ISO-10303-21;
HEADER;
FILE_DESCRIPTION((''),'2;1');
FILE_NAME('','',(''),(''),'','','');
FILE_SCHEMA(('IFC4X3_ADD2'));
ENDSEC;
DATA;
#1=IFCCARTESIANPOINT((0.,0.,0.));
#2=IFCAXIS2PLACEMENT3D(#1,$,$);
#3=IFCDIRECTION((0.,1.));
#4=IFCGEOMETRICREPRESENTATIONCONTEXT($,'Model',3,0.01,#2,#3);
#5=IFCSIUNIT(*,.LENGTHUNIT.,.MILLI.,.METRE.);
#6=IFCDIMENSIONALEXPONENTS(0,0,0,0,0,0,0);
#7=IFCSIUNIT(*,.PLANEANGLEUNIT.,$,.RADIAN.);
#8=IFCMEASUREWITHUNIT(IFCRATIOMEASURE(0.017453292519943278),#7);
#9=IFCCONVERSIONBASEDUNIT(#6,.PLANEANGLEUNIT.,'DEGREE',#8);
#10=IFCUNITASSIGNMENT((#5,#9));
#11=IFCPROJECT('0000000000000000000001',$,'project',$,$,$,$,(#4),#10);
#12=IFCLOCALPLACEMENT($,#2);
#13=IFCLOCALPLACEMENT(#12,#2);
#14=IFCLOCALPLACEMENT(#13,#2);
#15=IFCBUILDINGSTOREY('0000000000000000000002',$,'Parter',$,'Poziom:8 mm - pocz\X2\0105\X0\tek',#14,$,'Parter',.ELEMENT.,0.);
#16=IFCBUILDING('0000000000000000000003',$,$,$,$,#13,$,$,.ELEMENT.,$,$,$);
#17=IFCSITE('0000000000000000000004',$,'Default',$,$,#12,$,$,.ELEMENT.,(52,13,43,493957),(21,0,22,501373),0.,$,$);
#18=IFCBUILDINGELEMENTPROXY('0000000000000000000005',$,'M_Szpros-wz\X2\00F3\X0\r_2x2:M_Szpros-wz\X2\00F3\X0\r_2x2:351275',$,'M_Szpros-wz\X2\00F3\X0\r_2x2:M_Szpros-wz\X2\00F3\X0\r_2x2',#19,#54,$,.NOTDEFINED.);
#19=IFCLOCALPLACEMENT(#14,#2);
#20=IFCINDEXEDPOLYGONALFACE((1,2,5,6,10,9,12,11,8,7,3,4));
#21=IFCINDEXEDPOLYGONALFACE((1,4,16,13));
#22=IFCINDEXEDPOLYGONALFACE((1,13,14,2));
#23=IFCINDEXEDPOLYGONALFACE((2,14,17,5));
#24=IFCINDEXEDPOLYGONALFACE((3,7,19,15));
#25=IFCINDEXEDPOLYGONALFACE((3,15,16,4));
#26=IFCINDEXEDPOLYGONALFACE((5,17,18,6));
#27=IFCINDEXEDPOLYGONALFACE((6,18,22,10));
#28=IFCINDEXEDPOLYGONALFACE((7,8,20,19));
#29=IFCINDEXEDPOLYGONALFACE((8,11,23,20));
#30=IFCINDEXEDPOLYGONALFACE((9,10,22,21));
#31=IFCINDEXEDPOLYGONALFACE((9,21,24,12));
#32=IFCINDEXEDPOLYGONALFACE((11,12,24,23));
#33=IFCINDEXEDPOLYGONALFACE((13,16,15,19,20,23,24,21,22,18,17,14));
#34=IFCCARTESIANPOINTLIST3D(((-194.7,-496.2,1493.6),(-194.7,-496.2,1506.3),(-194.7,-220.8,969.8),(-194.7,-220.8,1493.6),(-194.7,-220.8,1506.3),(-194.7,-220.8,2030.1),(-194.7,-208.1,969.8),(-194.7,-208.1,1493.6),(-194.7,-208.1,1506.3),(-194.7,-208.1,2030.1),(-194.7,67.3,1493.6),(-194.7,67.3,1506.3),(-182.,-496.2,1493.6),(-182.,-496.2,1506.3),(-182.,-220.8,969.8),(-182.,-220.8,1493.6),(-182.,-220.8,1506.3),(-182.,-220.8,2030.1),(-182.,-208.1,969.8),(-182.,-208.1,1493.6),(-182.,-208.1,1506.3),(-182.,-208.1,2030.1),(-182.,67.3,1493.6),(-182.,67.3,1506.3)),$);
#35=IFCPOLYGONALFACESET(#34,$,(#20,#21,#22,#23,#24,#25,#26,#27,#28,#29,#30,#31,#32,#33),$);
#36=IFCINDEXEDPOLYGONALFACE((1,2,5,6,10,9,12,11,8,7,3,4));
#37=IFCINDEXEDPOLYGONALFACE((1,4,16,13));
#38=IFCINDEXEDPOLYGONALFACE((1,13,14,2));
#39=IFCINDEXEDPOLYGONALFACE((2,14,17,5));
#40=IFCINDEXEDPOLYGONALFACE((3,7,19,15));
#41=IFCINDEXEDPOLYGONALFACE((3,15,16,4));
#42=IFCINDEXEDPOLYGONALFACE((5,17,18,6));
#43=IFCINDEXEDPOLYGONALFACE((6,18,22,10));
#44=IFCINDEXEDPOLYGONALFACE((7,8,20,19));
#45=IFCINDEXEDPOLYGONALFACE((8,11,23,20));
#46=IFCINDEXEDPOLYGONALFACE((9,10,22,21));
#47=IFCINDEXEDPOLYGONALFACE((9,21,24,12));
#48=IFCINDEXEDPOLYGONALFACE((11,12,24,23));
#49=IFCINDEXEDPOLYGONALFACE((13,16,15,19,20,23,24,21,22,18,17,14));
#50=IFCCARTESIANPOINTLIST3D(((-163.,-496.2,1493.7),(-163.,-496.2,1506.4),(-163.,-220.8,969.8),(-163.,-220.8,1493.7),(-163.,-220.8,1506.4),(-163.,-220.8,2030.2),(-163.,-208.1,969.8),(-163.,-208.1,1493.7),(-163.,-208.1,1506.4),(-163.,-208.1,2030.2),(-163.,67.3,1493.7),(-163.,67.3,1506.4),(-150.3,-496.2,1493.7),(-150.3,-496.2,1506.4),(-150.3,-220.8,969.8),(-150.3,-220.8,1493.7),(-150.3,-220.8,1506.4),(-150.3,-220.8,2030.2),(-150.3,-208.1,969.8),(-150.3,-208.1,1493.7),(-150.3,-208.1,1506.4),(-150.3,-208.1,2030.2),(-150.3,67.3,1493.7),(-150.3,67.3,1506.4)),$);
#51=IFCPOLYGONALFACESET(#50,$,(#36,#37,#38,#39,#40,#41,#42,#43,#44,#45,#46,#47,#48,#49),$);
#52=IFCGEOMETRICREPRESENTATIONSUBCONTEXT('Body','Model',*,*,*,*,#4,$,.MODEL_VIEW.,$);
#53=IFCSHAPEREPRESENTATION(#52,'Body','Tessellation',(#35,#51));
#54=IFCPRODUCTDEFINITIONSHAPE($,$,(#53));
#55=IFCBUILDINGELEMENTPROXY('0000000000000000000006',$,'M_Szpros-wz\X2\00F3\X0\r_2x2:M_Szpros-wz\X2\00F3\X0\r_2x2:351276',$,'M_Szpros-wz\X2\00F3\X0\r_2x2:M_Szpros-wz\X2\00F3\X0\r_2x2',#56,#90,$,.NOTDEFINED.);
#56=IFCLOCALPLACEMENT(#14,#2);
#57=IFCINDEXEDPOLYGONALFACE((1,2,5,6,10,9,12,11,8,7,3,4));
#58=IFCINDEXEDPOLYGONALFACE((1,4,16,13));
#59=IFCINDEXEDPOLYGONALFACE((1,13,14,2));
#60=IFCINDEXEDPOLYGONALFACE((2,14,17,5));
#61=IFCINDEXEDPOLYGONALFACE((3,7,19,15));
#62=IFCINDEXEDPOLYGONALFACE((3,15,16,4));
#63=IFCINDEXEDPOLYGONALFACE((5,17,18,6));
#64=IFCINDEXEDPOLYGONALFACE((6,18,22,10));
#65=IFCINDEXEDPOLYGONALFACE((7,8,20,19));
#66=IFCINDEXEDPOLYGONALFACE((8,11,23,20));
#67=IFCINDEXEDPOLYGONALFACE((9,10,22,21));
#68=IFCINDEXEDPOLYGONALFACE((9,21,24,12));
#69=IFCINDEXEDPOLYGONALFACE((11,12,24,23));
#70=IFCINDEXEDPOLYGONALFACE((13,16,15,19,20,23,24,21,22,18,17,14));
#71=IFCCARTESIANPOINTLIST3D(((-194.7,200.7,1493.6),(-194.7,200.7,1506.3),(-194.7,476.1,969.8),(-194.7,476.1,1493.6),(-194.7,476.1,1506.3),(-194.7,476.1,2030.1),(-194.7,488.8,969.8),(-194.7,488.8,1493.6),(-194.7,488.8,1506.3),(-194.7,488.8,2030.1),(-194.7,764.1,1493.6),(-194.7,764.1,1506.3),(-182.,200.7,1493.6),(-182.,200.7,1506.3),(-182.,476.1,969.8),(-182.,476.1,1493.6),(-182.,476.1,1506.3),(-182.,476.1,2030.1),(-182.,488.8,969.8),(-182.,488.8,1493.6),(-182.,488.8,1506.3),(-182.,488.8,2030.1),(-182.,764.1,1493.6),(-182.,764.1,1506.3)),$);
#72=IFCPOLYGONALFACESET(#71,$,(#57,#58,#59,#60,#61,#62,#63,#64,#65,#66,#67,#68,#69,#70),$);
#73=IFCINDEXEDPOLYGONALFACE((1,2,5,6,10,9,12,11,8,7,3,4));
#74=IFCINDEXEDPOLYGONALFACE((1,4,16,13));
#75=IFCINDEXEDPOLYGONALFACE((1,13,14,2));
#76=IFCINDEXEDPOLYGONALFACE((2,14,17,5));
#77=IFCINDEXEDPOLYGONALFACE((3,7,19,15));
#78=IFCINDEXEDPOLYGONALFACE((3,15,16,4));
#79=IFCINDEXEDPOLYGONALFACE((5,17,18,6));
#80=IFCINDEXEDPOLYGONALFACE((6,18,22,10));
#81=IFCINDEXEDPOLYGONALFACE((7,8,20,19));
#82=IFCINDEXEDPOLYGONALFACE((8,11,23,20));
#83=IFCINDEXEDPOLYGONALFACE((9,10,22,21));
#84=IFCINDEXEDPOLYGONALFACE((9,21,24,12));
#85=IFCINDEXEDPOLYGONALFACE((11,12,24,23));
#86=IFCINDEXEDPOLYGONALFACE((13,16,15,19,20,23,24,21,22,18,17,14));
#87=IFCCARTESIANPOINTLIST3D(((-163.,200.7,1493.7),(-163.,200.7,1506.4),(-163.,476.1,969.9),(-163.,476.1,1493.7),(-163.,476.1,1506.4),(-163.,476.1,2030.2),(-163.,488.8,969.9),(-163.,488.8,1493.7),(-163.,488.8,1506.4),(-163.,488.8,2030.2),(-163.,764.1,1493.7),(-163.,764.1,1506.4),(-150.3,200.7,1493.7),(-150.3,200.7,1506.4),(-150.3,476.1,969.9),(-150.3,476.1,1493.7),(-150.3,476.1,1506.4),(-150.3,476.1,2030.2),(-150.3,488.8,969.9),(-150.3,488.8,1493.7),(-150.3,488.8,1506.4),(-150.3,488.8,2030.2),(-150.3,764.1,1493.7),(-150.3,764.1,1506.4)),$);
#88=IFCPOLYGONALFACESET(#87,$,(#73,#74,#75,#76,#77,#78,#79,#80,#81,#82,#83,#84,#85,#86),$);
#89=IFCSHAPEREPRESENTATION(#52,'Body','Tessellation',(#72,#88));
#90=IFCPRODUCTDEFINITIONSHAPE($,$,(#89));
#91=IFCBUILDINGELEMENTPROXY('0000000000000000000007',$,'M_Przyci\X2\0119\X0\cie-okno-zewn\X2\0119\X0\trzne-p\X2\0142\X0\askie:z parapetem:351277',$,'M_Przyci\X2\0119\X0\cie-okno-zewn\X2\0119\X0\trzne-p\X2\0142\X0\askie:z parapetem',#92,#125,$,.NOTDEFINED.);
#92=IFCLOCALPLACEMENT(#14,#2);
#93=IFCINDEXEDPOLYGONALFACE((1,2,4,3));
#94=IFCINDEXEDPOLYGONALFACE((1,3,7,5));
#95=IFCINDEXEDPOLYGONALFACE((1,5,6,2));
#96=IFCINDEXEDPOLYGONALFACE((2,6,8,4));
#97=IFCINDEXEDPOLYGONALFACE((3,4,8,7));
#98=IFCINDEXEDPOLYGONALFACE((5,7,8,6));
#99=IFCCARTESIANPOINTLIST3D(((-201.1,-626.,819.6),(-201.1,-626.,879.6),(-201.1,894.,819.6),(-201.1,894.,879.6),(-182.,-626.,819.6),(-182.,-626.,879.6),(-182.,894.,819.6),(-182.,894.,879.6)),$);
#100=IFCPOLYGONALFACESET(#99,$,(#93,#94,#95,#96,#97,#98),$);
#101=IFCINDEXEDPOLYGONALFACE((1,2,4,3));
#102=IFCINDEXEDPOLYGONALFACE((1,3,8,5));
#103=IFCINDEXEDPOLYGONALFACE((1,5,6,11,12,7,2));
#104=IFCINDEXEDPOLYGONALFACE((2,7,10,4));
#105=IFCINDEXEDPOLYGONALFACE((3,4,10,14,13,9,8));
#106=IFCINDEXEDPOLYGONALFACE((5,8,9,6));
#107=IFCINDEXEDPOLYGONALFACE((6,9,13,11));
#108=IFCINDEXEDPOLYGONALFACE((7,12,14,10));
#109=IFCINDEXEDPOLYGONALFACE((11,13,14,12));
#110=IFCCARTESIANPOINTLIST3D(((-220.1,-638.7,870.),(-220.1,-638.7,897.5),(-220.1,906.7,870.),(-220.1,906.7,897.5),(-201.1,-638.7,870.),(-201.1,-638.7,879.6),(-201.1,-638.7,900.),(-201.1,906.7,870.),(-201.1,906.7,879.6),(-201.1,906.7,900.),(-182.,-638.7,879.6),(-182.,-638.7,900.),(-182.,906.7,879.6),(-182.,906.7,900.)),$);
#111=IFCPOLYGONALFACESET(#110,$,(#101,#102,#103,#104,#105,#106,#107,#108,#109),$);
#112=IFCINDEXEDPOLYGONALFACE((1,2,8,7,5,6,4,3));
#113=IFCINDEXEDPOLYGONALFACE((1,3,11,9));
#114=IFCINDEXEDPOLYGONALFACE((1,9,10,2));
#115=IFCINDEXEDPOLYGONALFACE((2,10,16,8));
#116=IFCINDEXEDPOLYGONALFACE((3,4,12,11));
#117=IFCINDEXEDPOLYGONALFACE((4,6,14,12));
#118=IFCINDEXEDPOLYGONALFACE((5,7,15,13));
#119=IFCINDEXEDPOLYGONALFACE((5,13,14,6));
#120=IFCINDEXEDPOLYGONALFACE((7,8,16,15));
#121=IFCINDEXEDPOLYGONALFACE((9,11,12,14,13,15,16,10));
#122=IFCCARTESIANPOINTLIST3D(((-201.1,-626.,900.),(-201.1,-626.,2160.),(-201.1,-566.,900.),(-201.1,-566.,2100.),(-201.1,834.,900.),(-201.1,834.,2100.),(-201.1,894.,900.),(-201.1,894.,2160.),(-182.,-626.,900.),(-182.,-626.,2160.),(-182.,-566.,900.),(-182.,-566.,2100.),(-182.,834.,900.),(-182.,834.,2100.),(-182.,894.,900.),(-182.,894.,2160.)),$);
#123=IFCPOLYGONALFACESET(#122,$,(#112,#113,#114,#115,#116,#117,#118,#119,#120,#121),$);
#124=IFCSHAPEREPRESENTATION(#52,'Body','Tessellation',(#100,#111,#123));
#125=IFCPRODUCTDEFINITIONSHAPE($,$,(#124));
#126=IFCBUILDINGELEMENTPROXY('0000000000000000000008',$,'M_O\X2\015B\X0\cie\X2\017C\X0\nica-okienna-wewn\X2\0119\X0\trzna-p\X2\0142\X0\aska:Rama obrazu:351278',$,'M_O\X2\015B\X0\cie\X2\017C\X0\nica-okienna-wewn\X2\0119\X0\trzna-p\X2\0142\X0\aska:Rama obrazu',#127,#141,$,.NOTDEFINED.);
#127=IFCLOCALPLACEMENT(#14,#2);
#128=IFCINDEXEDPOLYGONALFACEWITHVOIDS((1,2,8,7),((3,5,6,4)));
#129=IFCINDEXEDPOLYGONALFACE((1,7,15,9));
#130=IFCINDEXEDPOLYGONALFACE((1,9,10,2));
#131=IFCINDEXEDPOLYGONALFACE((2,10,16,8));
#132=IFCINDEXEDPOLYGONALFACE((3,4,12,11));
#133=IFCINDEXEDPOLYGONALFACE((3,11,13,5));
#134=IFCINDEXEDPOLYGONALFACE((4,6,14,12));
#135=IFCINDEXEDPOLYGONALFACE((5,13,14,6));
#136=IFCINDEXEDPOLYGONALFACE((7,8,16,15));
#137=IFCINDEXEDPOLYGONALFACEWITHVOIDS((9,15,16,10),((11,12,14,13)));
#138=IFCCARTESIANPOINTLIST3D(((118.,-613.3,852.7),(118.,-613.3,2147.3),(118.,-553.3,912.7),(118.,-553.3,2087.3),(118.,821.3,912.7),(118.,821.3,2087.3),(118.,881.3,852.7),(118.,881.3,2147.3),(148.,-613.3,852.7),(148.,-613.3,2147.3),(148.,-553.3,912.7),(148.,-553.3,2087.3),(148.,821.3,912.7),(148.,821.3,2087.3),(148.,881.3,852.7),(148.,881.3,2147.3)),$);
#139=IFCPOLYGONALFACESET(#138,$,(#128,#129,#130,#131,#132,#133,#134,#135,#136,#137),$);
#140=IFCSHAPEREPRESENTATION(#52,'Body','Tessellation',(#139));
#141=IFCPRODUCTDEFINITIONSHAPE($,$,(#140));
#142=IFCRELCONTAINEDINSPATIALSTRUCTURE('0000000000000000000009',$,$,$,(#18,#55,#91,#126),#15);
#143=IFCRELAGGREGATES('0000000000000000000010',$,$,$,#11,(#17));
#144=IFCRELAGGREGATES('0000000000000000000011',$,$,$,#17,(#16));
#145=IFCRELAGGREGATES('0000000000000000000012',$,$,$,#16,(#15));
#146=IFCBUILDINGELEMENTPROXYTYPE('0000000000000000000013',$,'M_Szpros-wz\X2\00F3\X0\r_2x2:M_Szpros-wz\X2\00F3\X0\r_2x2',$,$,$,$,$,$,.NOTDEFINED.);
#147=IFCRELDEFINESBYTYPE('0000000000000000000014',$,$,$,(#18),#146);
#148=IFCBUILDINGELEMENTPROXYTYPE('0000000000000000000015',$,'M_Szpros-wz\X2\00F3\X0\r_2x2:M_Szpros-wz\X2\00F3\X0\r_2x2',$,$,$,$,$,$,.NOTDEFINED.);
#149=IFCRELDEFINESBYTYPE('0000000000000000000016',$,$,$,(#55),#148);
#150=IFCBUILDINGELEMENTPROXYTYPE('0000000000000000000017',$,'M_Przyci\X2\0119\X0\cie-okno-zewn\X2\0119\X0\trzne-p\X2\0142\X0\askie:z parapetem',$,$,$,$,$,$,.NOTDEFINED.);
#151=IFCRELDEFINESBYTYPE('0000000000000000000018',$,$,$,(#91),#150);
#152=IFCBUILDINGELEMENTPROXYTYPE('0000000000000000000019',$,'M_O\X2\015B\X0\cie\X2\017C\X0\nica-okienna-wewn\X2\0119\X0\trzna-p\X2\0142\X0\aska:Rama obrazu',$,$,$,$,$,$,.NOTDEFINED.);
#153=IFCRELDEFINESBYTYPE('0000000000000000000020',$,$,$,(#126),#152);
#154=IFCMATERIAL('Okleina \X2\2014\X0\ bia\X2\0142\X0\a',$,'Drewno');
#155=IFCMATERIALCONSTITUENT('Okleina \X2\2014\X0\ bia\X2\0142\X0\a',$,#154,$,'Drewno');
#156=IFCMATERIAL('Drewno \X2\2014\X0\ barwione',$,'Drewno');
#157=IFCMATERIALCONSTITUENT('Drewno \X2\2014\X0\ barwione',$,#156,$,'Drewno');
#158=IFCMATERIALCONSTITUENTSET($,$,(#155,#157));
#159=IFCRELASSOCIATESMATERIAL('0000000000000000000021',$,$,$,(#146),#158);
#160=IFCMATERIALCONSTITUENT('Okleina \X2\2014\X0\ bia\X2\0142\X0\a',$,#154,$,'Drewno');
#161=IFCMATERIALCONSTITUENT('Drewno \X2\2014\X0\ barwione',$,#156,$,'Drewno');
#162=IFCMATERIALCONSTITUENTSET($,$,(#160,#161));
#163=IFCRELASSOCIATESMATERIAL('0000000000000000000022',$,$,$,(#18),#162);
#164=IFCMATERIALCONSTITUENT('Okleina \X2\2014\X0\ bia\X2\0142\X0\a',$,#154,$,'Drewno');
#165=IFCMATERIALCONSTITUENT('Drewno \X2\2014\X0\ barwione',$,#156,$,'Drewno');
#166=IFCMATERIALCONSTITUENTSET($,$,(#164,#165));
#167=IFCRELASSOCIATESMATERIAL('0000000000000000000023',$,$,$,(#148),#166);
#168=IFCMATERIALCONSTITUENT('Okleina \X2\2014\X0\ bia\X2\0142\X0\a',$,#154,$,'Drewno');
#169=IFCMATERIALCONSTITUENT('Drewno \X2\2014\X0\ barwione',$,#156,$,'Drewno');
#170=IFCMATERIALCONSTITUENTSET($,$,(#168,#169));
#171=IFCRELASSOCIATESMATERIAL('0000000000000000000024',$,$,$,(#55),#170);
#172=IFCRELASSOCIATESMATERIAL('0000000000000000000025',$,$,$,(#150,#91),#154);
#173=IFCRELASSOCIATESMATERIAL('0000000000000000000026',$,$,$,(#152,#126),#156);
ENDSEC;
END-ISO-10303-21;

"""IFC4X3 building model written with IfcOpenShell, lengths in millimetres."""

from ifc_helpers import new_model, entity, si_unit, converted_unit, direction, frame, frame_2d, origin, place, context, subcontext, project, spatial, polyline, rectangle, outline, extrude, source, transform, mapped, material, constituent, constituent_set, type_object, type_shapes, element, save


model = new_model("IFC4X3")

# Units and contexts
model_context = context("Model", 3, precision=0.01, world=origin(), true_north=direction((0.0, 1.0)))
body_context = subcontext(model_context, "Body", "Model", "MODEL_VIEW")
ifc_project = project(units=[si_unit("LENGTHUNIT", "METRE", prefix="MILLI"), converted_unit("PLANEANGLEUNIT", "DEGREE", entity("IfcRatioMeasure", 0.017453292519943278), si_unit("PLANEANGLEUNIT", "RADIAN"), dimensions=[0, 0, 0, 0, 0, 0, 0])], contexts=[model_context])

# Site, building, storey
site_placement = place(None, origin())
site = spatial("IfcSite", under=ifc_project, at=site_placement, Name="Default", CompositionType="ELEMENT", RefLatitude=(52, 13, 43, 493957), RefLongitude=(21, 0, 22, 501373), RefElevation=0.0)
building_placement = place(site_placement, origin())
building = spatial("IfcBuilding", under=site, at=building_placement, CompositionType="ELEMENT")
storey_placement = place(building_placement, origin())
storey = spatial("IfcBuildingStorey", under=building, at=storey_placement, Name="Parter", ObjectType="Poziom:8 mm - początek", LongName="Parter", CompositionType="ELEMENT", Elevation=0.0)

# Building element proxies
ifc_material_1 = material(Name="Okleina — biała", Category="Drewno")
ifc_material_2 = material(Name="Drewno — barwione", Category="Drewno")
ifc_constituent_1 = constituent(ifc_material_1, Name="Okleina — biała", Category="Drewno")
ifc_constituent_2 = constituent(ifc_material_2, Name="Drewno — barwione", Category="Drewno")
ifc_constituent_set_1 = constituent_set(constituents=[ifc_constituent_1, ifc_constituent_2])
ifc_constituent_3 = constituent(ifc_material_1, Name="Okleina — biała", Category="Drewno")
ifc_constituent_4 = constituent(ifc_material_2, Name="Drewno — barwione", Category="Drewno")
ifc_constituent_set_2 = constituent_set(constituents=[ifc_constituent_3, ifc_constituent_4])
building_element_proxy_type_1 = type_object("IfcBuildingElementProxyType", Name="M_Szpros-wzór_2x2:M_Szpros-wzór_2x2", PredefinedType="NOTDEFINED", material=ifc_constituent_set_2)
shared_shape_1 = source(origin(), body_context, "Body", "SweptSolid", [
    extrude(outline(polyline([(6.4, -6.4), (530.1, -6.4), (530.1, 6.3), (6.4, 6.3), (6.4, 281.7), (-6.3, 281.7), (-6.3, 6.3), (-530.2, 6.3), (-530.2, -6.4), (-6.3, -6.4), (-6.3, -281.7), (6.4, -281.7), (6.4, -6.4)])), frame((0.0, 9.5, 530.1), z_axis=(0.0, 1.0, 0.0), x_axis=(0.0, 0.0, 1.0)), (0.0, 0.0, 1.0), 12.7),
    extrude(outline(polyline([(6.4, -6.4), (530.2, -6.4), (530.2, 6.3), (6.4, 6.3), (6.4, 281.7), (-6.3, 281.7), (-6.3, 6.3), (-530.2, 6.3), (-530.2, -6.4), (-6.3, -6.4), (-6.3, -281.7), (6.4, -281.7), (6.4, -6.4)])), frame((0.0, -22.2, 530.2), z_axis=(0.0, 1.0, 0.0), x_axis=(0.0, 0.0, 1.0)), (0.0, 0.0, 1.0), 12.7),
])
type_shapes(building_element_proxy_type_1, [shared_shape_1])
proxy_1_placement = place(storey_placement, frame((-172.5, -214.4, 969.8), z_axis=(0.0, 0.0, 1.0), x_axis=(0.0, 1.0, 0.0)))
element("IfcBuildingElementProxy", 1, at=proxy_1_placement, inside=storey, type_object=building_element_proxy_type_1, material=ifc_constituent_set_1, Name="M_Szpros-wzór_2x2:M_Szpros-wzór_2x2:351275", ObjectType="M_Szpros-wzór_2x2:M_Szpros-wzór_2x2", PredefinedType="NOTDEFINED", context=body_context, shape_type="MappedRepresentation", body=[
    mapped(shared_shape_1, transform((0.0, 0.0, 0.0), scale=1.0)),
])
ifc_constituent_5 = constituent(ifc_material_1, Name="Okleina — biała", Category="Drewno")
ifc_constituent_6 = constituent(ifc_material_2, Name="Drewno — barwione", Category="Drewno")
ifc_constituent_set_3 = constituent_set(constituents=[ifc_constituent_5, ifc_constituent_6])
ifc_constituent_7 = constituent(ifc_material_1, Name="Okleina — biała", Category="Drewno")
ifc_constituent_8 = constituent(ifc_material_2, Name="Drewno — barwione", Category="Drewno")
ifc_constituent_set_4 = constituent_set(constituents=[ifc_constituent_7, ifc_constituent_8])
building_element_proxy_type_2 = type_object("IfcBuildingElementProxyType", Name="M_Szpros-wzór_2x2:M_Szpros-wzór_2x2", PredefinedType="NOTDEFINED", material=ifc_constituent_set_4)
shared_shape_2 = source(origin(), body_context, "Body", "SweptSolid", [
    extrude(outline(polyline([(6.4, -6.4), (530.1, -6.4), (530.1, 6.3), (6.4, 6.3), (6.4, 281.7), (-6.3, 281.7), (-6.3, 6.3), (-530.2, 6.3), (-530.2, -6.4), (-6.3, -6.4), (-6.3, -281.7), (6.4, -281.7), (6.4, -6.4)])), frame((0.0, -22.2, 530.1), z_axis=(0.0, 1.0, 0.0), x_axis=(0.0, 0.0, 1.0)), (0.0, 0.0, 1.0), 12.7),
    extrude(outline(polyline([(6.4, -6.4), (530.2, -6.4), (530.2, 6.3), (6.4, 6.3), (6.4, 281.7), (-6.3, 281.7), (-6.3, 6.3), (-530.2, 6.3), (-530.2, -6.4), (-6.3, -6.4), (-6.3, -281.7), (6.4, -281.7), (6.4, -6.4)])), frame((0.0, 9.5, 530.2), z_axis=(0.0, 1.0, 0.0), x_axis=(0.0, 0.0, 1.0)), (0.0, 0.0, 1.0), 12.7),
])
type_shapes(building_element_proxy_type_2, [shared_shape_2])
proxy_2_placement = place(storey_placement, frame((-172.5, 482.4, 969.9), z_axis=(0.0, 0.0, 1.0), x_axis=(0.0, -1.0, 0.0)))
element("IfcBuildingElementProxy", 2, at=proxy_2_placement, inside=storey, type_object=building_element_proxy_type_2, material=ifc_constituent_set_3, Name="M_Szpros-wzór_2x2:M_Szpros-wzór_2x2:351276", ObjectType="M_Szpros-wzór_2x2:M_Szpros-wzór_2x2", PredefinedType="NOTDEFINED", context=body_context, shape_type="MappedRepresentation", body=[
    mapped(shared_shape_2, transform((0.0, 0.0, 0.0), scale=1.0)),
])
building_element_proxy_type_3 = type_object("IfcBuildingElementProxyType", Name="M_Przycięcie-okno-zewnętrzne-płaskie:z parapetem", PredefinedType="NOTDEFINED", material=ifc_material_1)
shared_shape_3 = source(origin(), body_context, "Body", "SweptSolid", [
    extrude(rectangle(XDim=1520.0, YDim=60.0, at=frame_2d((0.0, 0.0), x_axis=(1.0, 0.0))), frame((0.0, -1250.4, 0.0), z_axis=(0.0, 0.0, 1.0), x_axis=(-1.0, 0.0, 0.0)), (0.0, 0.0, 1.0), 19.0),
    extrude(outline(polyline([(-19.0, -15.2), (0.0, -15.2), (0.0, -5.7), (19.0, -5.7), (19.0, 14.8), (0.0, 14.8), (-19.0, 12.3), (-19.0, -15.2)])), frame((-772.7, -1214.8, 19.0), z_axis=(1.0, 0.0, 0.0), x_axis=(0.0, 0.0, -1.0)), (0.0, 0.0, 1.0), 1545.4),
    extrude(outline(polyline([(-645.0, -760.0), (615.0, -760.0), (615.0, -700.0), (-585.0, -700.0), (-585.0, 700.0), (615.0, 700.0), (615.0, 760.0), (-645.0, 760.0), (-645.0, -760.0)])), frame((0.0, -585.0, 0.0), z_axis=(0.0, 0.0, 1.0), x_axis=(0.0, -1.0, 0.0)), (0.0, 0.0, 1.0), 19.0),
])
type_shapes(building_element_proxy_type_3, [shared_shape_3])
proxy_3_placement = place(storey_placement, frame((-182.0, 134.0, 2100.0), z_axis=(-1.0, 0.0, 0.0), x_axis=(0.0, -1.0, 0.0)))
element("IfcBuildingElementProxy", 3, at=proxy_3_placement, inside=storey, type_object=building_element_proxy_type_3, material=ifc_material_1, Name="M_Przycięcie-okno-zewnętrzne-płaskie:z parapetem:351277", ObjectType="M_Przycięcie-okno-zewnętrzne-płaskie:z parapetem", PredefinedType="NOTDEFINED", context=body_context, shape_type="MappedRepresentation", body=[
    mapped(shared_shape_3, transform((0.0, 0.0, 0.0), scale=1.0)),
])
building_element_proxy_type_4 = type_object("IfcBuildingElementProxyType", Name="M_Ościeżnica-okienna-wewnętrzna-płaska:Rama obrazu", PredefinedType="NOTDEFINED", material=ifc_material_2)
shared_shape_4 = source(origin(), body_context, "Body", "SweptSolid", [
    extrude(outline(polyline([(-747.3, -647.3), (747.3, -647.3), (747.3, 647.3), (-747.3, 647.3), (-747.3, -647.3)]), holes=[polyline([(-687.3, -587.3), (-687.3, 587.3), (687.3, 587.3), (687.3, -587.3), (-687.3, -587.3)])]), frame((0.0, -600.0, 0.0), z_axis=(0.0, 0.0, 1.0), x_axis=(-1.0, 0.0, 0.0)), (0.0, 0.0, 1.0), 30.0),
])
type_shapes(building_element_proxy_type_4, [shared_shape_4])
proxy_4_placement = place(storey_placement, frame((118.0, 134.0, 2100.0), z_axis=(1.0, 0.0, 0.0), x_axis=(0.0, 1.0, 0.0)))
element("IfcBuildingElementProxy", 4, at=proxy_4_placement, inside=storey, type_object=building_element_proxy_type_4, material=ifc_material_2, Name="M_Ościeżnica-okienna-wewnętrzna-płaska:Rama obrazu:351278", ObjectType="M_Ościeżnica-okienna-wewnętrzna-płaska:Rama obrazu", PredefinedType="NOTDEFINED", context=body_context, shape_type="MappedRepresentation", body=[
    mapped(shared_shape_4, transform((0.0, 0.0, 0.0), scale=1.0)),
])

save(model, "model.ifc")
